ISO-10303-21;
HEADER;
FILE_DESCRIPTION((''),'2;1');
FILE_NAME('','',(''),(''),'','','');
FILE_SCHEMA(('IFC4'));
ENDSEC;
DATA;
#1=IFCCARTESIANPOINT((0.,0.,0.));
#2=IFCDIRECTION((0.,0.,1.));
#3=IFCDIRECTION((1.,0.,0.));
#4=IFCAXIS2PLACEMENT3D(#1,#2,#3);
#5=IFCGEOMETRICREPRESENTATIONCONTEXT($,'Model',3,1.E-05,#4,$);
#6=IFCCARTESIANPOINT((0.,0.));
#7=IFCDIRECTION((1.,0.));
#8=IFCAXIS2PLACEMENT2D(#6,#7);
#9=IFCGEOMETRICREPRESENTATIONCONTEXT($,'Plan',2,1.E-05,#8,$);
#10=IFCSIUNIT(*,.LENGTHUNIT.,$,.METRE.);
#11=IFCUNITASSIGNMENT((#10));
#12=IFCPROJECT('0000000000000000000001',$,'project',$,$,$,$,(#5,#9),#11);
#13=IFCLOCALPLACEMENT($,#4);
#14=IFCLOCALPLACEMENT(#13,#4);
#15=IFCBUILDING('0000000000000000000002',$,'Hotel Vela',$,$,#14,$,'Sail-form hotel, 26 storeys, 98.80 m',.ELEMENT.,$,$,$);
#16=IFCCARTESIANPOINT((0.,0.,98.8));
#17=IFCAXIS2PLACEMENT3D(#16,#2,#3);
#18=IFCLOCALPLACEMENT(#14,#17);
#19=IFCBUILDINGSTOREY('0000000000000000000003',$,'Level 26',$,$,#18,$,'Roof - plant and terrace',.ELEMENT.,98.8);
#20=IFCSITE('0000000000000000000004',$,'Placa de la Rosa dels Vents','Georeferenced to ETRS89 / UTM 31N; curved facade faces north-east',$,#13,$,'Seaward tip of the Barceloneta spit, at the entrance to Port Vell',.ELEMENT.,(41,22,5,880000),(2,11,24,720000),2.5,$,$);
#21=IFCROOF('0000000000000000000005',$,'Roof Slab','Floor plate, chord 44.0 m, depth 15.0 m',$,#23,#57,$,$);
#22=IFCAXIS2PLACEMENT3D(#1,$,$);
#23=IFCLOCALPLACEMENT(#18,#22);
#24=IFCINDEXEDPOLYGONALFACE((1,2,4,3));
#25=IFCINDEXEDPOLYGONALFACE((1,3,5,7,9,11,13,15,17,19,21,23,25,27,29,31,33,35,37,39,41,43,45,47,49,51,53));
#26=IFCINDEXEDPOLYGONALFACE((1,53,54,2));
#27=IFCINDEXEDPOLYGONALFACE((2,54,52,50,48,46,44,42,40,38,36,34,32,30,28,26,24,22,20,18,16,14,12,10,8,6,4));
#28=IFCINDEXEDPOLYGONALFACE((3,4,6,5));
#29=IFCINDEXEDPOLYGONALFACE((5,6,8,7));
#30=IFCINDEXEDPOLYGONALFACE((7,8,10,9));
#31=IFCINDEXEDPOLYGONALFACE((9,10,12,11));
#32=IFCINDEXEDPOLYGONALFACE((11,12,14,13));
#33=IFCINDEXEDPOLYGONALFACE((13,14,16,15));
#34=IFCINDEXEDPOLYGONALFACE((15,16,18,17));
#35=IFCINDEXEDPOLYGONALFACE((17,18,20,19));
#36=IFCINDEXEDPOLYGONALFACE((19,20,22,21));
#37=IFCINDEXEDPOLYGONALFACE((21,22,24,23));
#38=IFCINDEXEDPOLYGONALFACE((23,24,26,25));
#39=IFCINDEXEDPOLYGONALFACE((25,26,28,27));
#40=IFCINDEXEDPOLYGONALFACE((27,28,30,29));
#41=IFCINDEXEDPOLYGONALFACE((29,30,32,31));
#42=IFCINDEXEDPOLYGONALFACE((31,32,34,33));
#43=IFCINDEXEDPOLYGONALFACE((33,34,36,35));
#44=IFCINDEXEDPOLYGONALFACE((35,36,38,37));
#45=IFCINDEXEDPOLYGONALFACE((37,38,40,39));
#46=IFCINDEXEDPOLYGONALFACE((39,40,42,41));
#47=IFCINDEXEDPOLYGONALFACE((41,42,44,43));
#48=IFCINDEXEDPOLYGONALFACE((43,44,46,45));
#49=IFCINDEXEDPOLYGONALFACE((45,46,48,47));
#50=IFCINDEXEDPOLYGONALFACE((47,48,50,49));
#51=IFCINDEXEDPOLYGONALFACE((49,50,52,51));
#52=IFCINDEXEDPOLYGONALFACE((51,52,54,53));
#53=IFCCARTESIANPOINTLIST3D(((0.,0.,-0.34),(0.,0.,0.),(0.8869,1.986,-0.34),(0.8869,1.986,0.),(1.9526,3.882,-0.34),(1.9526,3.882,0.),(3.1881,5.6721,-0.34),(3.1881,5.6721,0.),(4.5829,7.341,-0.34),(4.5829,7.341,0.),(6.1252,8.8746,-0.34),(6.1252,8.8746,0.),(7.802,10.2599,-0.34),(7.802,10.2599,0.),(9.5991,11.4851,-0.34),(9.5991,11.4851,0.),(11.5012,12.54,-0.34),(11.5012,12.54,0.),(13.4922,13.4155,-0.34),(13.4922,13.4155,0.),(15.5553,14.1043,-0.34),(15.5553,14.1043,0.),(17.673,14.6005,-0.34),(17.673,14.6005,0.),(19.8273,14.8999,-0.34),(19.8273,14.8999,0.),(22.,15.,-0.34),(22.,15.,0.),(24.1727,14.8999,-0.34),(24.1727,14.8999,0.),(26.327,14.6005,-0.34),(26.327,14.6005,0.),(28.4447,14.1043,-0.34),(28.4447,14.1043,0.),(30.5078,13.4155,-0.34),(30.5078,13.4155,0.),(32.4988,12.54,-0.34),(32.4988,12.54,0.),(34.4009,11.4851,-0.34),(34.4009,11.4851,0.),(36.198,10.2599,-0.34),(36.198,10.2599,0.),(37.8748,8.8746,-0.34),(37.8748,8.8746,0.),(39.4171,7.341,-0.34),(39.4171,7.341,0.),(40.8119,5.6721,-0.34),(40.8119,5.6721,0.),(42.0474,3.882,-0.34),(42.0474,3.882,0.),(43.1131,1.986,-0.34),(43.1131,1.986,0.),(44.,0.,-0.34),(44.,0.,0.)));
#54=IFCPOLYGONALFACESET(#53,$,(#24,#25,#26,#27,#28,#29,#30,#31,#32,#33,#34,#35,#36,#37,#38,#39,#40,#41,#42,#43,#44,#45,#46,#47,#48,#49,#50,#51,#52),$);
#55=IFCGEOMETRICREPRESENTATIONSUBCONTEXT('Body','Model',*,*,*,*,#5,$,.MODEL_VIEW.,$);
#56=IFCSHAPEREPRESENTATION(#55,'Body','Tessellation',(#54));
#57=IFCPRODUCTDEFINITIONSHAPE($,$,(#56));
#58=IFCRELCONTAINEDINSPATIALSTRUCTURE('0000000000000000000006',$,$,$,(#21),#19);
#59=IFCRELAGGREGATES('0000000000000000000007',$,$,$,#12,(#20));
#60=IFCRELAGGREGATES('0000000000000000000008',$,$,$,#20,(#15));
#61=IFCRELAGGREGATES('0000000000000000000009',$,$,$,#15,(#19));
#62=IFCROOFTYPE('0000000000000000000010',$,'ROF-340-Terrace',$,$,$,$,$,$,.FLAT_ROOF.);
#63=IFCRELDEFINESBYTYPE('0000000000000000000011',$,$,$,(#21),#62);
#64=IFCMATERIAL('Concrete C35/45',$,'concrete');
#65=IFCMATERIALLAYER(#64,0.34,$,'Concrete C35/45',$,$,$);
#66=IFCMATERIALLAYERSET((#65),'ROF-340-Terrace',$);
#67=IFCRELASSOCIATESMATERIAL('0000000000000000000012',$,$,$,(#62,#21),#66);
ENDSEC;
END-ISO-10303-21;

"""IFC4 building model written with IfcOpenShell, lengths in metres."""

from ifc_helpers import new_model, si_unit, frame, origin_with_axes, origin_2d_with_axis, place, context, subcontext, project, spatial, line, indexed_curve, outline, extrude, material, layer, layer_set, layer_usage, type_object, element, save


model = new_model("IFC4")

# Units and contexts
model_context = context("Model", 3, precision=1e-05, world=origin_with_axes())
plan_context = context("Plan", 2, precision=1e-05, world=origin_2d_with_axis())
body_context = subcontext(model_context, "Body", "Model", "MODEL_VIEW")
ifc_project = project(units=[si_unit("LENGTHUNIT", "METRE")], contexts=[model_context, plan_context])

# Site, building, storey
site_placement = place(None, origin_with_axes())
site = spatial("IfcSite", under=ifc_project, at=site_placement, Name="Placa de la Rosa dels Vents", Description="Georeferenced to ETRS89 / UTM 31N; curved facade faces north-east", LongName="Seaward tip of the Barceloneta spit, at the entrance to Port Vell", CompositionType="ELEMENT", RefLatitude=(41, 22, 5, 880000), RefLongitude=(2, 11, 24, 720000), RefElevation=2.5)
building_placement = place(site_placement, origin_with_axes())
building = spatial("IfcBuilding", under=site, at=building_placement, Name="Hotel Vela", LongName="Sail-form hotel, 26 storeys, 98.80 m", CompositionType="ELEMENT")
storey_placement = place(building_placement, frame((0.0, 0.0, 98.8), z_axis=(0.0, 0.0, 1.0), x_axis=(1.0, 0.0, 0.0)))
storey = spatial("IfcBuildingStorey", under=building, at=storey_placement, Name="Level 26", LongName="Roof - plant and terrace", CompositionType="ELEMENT", Elevation=98.8)

# Roof
ifc_material = material(Name="Concrete C35/45", Category="concrete")
ifc_layer = layer(ifc_material, 0.34, Name="Concrete C35/45")
ifc_layer_set = layer_set([ifc_layer], Name="ROF-340-Terrace")
ifc_layer_usage = layer_usage(ifc_layer_set, "AXIS3", "POSITIVE", 0.0)
roof_type = type_object("IfcRoofType", Name="ROF-340-Terrace", PredefinedType="FLAT_ROOF", material=ifc_layer_set)
roof_placement = place(storey_placement, frame((0.0, 0.0, -0.34), z_axis=(0.0, 0.0, 1.0), x_axis=(1.0, 0.0, 0.0)))
element("IfcRoof", 1, at=roof_placement, inside=storey, type_object=roof_type, material=ifc_layer_usage, Name="Roof Slab", Description="Floor plate, chord 44.0 m, depth 15.0 m", context=body_context, shape_type="SweptSolid", body=[
    extrude(outline(indexed_curve([(0.0, 0.0), (44.0, 0.0), (43.1131, 1.986), (42.0474, 3.882), (40.8119, 5.6721), (39.4171, 7.341), (37.8748, 8.8746), (36.198, 10.2599), (34.4009, 11.4851), (32.4988, 12.54), (30.5078, 13.4155), (28.4447, 14.1043), (26.327, 14.6005), (24.1727, 14.8999), (22.0, 15.0), (19.8273, 14.8999), (17.673, 14.6005), (15.5553, 14.1043), (13.4922, 13.4155), (11.5012, 12.54), (9.5991, 11.4851), (7.802, 10.2599), (6.1252, 8.8746), (4.5829, 7.341), (3.1881, 5.6721), (1.9526, 3.882), (0.8869, 1.986)], segments=[line(1, 2, 3, 4, 5, 6, 7, 8, 9, 10, 11, 12, 13, 14, 15, 16, 17, 18, 19, 20, 21, 22, 23, 24, 25, 26, 27, 1)])), origin_with_axes(), (0.0, 0.0, 1.0), 0.34),
])

save(model, "model.ifc")
